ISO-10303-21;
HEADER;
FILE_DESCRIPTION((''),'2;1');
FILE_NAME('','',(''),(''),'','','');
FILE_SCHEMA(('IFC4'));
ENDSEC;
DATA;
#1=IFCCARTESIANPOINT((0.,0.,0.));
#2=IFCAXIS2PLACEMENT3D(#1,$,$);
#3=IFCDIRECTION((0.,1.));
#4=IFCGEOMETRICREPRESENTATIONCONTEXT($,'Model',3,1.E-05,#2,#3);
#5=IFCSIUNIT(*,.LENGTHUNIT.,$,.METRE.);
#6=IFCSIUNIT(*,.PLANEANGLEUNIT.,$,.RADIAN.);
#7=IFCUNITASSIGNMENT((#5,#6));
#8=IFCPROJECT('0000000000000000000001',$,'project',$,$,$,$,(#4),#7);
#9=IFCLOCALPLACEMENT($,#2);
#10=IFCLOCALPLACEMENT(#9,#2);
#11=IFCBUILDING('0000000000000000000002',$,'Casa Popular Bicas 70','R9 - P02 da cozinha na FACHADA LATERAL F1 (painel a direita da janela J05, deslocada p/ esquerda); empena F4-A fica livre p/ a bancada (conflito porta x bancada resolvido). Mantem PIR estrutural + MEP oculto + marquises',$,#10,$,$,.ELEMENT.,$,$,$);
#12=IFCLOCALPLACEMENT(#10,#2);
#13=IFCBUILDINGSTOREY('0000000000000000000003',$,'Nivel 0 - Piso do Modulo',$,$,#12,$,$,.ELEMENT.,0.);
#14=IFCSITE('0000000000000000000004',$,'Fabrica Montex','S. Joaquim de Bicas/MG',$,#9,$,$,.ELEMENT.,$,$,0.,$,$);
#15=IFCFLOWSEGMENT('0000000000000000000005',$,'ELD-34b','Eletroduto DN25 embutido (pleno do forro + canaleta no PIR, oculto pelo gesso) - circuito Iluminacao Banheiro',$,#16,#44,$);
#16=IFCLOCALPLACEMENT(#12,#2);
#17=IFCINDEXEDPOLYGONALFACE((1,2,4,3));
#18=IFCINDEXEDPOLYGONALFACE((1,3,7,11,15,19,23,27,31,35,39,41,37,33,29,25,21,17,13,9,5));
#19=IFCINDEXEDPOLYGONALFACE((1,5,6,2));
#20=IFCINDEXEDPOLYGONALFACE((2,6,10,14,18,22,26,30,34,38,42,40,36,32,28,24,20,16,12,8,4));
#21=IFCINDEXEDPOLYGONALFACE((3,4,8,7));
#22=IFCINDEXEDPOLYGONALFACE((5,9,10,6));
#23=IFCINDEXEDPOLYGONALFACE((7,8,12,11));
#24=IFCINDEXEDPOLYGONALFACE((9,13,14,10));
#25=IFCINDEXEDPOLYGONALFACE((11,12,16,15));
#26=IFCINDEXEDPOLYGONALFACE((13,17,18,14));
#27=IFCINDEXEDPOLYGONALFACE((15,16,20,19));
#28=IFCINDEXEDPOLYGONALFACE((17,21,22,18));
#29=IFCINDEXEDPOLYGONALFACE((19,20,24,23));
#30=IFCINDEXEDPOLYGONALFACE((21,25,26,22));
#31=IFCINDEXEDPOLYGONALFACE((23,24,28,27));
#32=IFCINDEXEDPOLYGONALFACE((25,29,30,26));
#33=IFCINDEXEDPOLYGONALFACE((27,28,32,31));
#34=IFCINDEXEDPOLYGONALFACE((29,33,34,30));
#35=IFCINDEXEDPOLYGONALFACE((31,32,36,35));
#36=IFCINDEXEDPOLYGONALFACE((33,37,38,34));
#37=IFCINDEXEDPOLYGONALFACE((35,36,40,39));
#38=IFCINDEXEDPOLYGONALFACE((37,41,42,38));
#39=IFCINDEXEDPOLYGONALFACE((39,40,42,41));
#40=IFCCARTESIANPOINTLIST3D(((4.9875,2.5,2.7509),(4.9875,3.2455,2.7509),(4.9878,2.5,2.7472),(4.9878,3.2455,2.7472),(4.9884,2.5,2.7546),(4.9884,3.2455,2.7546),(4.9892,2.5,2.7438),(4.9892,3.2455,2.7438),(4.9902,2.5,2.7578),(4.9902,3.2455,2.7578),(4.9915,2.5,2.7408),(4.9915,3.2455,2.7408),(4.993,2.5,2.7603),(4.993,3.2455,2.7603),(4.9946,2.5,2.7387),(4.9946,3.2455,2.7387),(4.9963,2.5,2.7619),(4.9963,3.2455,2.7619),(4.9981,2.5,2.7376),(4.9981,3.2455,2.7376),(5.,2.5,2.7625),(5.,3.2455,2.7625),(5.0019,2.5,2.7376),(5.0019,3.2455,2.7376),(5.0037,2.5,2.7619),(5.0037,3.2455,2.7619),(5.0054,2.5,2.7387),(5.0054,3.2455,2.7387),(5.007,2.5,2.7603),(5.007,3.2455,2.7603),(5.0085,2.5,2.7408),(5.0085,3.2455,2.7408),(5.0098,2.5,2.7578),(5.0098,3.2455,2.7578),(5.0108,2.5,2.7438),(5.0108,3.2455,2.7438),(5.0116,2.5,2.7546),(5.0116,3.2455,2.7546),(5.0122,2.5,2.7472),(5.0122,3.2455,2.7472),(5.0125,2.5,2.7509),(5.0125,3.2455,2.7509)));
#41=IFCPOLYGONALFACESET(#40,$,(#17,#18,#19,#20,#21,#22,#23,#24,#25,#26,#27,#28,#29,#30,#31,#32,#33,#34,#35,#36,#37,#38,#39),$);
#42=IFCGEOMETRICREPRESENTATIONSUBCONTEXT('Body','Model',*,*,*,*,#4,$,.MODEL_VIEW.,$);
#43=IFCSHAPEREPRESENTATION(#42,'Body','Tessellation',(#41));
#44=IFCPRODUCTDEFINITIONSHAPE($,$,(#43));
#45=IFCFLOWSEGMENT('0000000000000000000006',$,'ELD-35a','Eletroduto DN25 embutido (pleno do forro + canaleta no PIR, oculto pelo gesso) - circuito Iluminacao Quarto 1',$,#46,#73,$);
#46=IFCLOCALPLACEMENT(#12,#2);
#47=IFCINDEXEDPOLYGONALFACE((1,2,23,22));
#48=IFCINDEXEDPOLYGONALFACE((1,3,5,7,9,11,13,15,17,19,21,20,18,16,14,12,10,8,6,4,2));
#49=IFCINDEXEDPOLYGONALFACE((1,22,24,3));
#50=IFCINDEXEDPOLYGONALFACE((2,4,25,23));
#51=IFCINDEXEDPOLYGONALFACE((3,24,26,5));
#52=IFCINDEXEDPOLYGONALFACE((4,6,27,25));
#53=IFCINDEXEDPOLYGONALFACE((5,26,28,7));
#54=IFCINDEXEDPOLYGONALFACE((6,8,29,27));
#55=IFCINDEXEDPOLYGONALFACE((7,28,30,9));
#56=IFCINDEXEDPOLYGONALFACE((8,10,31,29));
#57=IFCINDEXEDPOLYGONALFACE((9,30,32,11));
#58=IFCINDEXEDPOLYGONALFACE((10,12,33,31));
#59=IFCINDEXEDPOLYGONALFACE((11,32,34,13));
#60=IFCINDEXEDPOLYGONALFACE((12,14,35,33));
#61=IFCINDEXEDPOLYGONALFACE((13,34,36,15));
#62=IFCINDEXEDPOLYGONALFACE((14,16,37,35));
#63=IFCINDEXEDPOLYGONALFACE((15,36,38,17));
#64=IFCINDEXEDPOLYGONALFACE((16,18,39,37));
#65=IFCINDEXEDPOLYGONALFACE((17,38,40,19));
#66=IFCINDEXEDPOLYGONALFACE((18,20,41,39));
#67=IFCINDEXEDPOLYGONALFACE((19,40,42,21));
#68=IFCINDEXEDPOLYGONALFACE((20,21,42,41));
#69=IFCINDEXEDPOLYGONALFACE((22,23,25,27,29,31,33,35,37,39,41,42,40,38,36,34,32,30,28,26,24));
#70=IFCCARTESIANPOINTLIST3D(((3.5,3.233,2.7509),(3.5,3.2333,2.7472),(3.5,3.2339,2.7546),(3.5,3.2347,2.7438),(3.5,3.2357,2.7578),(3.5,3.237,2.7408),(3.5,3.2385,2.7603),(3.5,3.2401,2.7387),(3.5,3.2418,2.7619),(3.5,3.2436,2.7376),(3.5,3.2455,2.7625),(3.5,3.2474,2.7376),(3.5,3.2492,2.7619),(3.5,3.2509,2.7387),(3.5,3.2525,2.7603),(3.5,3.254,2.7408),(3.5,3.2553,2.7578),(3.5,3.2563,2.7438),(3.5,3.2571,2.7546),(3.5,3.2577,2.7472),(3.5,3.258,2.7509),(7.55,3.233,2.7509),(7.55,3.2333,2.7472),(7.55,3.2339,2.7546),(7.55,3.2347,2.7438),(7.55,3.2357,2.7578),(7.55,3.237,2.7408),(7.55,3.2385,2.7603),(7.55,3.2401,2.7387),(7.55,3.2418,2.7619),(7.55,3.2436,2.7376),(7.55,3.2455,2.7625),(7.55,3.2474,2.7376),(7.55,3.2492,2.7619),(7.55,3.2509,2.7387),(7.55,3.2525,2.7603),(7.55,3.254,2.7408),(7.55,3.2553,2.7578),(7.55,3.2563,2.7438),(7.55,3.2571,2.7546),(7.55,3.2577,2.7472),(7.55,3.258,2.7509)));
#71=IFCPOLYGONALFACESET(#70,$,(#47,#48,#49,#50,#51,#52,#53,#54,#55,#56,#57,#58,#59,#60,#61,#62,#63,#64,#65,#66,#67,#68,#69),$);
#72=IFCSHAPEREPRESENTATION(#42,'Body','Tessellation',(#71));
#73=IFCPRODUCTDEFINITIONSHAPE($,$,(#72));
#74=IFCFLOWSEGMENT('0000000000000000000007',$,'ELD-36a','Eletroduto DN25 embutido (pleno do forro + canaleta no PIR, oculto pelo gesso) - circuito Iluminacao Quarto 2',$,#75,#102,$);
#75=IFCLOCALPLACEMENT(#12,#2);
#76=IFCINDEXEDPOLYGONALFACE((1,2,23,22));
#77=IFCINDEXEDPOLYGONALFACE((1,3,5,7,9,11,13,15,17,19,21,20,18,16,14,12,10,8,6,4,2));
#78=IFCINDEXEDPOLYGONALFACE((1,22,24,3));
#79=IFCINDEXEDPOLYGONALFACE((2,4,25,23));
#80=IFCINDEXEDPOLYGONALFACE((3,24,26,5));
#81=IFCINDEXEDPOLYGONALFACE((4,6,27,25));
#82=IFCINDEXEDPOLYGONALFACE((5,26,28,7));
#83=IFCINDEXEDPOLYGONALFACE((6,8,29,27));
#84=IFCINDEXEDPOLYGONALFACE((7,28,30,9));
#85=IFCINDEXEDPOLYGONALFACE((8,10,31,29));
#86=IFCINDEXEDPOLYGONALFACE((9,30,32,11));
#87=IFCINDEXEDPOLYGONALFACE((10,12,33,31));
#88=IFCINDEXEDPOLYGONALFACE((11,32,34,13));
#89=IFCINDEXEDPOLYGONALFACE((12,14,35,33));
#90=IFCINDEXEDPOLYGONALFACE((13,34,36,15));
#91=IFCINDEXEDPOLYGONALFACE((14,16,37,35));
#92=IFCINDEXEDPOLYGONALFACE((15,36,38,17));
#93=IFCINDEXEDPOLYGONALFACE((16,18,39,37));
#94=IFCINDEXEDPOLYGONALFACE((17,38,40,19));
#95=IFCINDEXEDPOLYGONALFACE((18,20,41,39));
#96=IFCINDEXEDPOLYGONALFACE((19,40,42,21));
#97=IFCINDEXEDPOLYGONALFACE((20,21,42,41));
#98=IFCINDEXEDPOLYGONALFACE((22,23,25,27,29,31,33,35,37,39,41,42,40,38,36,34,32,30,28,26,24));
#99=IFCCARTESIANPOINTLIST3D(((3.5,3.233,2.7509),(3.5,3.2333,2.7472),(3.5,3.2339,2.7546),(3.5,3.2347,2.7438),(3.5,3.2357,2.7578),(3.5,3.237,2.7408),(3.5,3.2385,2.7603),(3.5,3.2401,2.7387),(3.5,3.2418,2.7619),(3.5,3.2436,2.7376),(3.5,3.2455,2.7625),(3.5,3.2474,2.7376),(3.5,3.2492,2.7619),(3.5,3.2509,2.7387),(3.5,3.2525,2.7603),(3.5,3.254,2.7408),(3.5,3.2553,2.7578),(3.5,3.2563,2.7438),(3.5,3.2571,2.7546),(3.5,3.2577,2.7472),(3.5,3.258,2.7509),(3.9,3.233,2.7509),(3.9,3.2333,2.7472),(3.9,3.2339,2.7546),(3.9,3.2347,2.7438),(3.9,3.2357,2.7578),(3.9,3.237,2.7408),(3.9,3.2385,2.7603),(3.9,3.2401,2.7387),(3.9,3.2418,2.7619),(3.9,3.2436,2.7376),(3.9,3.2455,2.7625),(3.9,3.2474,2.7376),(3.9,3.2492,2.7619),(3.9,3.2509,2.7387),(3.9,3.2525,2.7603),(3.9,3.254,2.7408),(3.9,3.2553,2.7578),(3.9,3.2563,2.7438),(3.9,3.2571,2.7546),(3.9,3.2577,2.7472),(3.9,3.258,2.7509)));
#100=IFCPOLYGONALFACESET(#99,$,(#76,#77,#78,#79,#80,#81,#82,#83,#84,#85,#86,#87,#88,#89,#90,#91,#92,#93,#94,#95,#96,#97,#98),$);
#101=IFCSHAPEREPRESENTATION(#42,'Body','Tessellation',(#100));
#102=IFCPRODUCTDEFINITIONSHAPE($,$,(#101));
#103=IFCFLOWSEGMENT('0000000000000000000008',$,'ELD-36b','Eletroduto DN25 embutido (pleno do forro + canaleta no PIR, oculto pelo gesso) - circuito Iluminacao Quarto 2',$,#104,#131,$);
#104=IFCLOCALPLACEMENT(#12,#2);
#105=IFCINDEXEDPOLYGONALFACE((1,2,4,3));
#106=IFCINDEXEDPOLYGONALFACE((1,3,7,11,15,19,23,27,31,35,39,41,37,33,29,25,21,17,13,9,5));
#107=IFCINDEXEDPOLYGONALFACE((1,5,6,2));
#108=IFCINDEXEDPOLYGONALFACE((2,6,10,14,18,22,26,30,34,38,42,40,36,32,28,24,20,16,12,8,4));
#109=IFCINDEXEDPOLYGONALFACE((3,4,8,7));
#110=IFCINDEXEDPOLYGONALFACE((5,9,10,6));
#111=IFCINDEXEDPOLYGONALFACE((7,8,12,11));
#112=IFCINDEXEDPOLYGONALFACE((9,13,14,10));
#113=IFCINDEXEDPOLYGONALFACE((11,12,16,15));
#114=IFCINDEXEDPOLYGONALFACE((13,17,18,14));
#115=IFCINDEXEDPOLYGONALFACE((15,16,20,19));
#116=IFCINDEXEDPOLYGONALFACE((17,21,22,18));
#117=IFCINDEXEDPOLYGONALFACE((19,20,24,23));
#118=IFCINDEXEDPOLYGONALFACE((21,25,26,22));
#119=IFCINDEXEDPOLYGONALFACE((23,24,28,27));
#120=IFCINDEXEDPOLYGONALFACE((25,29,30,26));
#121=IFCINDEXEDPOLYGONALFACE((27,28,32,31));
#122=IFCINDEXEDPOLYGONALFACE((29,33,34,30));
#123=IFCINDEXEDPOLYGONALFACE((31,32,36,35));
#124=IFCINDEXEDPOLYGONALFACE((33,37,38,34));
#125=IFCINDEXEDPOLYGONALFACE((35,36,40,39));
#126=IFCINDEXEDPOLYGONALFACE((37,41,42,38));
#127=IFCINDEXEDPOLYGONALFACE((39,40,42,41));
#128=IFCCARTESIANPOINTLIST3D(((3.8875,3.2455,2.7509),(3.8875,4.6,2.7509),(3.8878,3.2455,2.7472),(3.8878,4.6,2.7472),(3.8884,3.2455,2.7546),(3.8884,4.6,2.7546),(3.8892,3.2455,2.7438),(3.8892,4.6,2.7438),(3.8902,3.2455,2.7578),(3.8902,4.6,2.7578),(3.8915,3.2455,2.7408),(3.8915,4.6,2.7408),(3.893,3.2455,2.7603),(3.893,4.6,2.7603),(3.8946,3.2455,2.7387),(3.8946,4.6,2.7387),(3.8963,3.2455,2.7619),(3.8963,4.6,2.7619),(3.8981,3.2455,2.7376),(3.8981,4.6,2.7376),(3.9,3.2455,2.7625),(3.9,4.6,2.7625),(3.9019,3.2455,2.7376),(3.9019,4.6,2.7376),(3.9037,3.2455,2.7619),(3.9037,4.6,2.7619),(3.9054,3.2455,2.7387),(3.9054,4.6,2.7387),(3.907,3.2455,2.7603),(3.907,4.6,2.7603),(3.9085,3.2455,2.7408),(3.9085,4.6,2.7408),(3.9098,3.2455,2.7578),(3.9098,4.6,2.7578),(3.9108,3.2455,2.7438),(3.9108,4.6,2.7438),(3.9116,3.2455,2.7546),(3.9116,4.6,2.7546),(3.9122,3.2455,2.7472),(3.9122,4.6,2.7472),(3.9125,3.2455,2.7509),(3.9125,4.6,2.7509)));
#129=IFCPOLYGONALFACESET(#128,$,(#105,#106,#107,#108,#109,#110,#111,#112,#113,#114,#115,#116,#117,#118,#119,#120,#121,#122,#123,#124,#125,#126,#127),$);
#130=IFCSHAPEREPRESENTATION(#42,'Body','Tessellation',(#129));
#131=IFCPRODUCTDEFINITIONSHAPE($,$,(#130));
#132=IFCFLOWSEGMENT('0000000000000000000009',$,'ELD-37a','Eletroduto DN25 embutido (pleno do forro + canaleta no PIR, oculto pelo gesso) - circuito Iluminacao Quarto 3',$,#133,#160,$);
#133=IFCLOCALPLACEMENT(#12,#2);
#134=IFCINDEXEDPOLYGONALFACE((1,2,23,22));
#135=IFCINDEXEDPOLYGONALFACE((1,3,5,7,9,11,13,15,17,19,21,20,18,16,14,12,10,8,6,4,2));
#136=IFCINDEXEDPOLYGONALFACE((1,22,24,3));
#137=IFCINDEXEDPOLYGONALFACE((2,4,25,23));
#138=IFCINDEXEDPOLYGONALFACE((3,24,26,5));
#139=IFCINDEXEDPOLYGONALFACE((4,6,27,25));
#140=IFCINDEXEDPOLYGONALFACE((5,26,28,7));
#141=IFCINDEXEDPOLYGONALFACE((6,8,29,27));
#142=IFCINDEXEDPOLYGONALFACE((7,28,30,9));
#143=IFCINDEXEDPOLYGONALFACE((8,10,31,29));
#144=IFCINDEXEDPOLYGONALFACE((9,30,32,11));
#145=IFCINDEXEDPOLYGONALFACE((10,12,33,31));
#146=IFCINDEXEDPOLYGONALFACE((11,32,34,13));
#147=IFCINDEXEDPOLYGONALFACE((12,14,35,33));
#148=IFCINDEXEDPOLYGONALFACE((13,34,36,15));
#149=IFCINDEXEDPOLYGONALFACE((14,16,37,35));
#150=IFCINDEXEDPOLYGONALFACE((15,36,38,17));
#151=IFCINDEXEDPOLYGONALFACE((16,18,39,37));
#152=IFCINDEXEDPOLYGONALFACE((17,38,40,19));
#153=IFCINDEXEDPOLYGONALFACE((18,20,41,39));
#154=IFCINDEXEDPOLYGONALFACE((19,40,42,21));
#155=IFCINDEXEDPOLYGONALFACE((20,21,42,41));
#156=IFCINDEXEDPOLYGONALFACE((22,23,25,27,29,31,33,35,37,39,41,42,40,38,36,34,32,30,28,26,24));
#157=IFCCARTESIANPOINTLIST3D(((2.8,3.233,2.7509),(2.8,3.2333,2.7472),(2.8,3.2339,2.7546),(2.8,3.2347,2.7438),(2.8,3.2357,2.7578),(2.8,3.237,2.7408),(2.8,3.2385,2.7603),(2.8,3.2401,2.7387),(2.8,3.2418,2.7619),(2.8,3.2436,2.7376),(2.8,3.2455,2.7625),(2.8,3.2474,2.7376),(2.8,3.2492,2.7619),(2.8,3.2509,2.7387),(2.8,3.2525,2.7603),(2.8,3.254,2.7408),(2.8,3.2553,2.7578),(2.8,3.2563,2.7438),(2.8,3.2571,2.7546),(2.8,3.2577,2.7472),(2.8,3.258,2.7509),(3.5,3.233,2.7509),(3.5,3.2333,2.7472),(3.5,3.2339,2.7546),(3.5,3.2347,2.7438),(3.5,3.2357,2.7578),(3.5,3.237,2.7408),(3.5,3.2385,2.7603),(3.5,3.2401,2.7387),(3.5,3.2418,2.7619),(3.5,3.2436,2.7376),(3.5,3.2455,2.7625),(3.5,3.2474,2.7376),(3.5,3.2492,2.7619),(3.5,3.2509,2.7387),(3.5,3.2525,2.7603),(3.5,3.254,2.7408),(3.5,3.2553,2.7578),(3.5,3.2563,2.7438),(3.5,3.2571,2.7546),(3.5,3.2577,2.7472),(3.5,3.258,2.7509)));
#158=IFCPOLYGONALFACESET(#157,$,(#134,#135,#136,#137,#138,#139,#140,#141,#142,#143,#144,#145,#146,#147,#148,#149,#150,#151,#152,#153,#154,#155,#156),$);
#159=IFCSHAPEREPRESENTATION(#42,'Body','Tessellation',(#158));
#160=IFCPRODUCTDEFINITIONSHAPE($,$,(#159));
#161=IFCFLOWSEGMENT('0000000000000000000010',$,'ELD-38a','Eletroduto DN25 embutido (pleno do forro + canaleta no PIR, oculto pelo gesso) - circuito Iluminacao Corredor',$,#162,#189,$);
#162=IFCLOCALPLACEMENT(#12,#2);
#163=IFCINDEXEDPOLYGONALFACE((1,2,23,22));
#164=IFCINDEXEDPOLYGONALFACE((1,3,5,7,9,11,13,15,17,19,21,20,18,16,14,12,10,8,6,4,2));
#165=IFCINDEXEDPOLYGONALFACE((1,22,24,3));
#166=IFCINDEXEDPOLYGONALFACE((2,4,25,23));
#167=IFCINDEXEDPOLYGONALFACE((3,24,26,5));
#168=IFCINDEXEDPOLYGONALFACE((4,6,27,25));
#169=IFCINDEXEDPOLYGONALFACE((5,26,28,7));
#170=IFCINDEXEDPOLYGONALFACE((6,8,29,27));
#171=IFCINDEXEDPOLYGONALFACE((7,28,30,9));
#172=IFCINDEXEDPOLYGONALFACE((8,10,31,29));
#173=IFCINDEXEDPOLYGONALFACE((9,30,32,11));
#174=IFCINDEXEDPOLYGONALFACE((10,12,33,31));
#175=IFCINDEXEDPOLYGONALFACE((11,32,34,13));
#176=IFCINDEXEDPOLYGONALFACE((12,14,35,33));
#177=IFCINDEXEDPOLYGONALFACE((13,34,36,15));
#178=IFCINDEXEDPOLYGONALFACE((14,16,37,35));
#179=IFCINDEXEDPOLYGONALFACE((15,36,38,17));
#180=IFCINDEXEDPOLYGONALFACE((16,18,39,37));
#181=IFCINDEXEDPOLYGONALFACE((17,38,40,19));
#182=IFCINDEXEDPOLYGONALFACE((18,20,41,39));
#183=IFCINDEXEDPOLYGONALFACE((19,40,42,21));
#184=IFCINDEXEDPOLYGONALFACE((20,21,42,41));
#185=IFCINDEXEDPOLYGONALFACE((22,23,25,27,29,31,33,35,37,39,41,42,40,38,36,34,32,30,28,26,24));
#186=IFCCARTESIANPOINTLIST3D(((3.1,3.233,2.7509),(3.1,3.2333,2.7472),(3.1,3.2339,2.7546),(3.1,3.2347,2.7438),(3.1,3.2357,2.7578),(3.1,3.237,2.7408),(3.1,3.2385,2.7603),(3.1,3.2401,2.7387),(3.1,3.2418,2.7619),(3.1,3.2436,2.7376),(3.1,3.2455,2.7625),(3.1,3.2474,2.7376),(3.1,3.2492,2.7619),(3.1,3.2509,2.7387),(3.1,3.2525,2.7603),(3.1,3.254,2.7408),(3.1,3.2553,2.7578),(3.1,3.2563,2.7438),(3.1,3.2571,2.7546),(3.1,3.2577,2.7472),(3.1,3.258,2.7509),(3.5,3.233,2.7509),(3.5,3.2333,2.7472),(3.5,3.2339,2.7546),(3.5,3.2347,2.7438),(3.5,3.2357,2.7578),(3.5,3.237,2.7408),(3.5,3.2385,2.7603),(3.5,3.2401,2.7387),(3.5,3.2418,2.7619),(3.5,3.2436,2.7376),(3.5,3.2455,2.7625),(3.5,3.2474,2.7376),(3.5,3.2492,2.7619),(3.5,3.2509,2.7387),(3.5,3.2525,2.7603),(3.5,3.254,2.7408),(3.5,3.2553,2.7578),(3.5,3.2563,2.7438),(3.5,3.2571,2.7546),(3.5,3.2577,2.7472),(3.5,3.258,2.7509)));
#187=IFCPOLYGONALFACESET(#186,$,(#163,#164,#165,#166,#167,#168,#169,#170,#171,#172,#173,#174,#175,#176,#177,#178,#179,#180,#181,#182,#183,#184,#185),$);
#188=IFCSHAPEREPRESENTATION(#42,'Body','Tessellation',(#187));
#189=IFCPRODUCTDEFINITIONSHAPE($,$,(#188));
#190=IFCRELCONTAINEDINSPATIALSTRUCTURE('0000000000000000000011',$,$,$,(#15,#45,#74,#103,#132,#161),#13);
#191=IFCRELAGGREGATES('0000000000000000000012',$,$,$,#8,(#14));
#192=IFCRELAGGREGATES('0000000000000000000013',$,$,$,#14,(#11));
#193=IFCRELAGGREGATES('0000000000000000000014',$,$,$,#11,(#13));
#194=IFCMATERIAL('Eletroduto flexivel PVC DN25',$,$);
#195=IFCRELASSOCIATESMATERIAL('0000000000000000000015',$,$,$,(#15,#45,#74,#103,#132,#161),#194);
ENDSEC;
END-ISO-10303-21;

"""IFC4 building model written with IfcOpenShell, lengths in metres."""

from ifc_helpers import new_model, si_unit, direction, frame, origin, origin_2d, place, context, subcontext, project, spatial, circle, extrude, material, element, save


model = new_model("IFC4")

# Units and contexts
model_context = context("Model", 3, precision=1e-05, world=origin(), true_north=direction((0.0, 1.0)))
body_context = subcontext(model_context, "Body", "Model", "MODEL_VIEW")
ifc_project = project(units=[si_unit("LENGTHUNIT", "METRE"), si_unit("PLANEANGLEUNIT", "RADIAN")], contexts=[model_context])

# Site, building, storey
site_placement = place(None, origin())
site = spatial("IfcSite", under=ifc_project, at=site_placement, Name="Fabrica Montex", Description="S. Joaquim de Bicas/MG", CompositionType="ELEMENT", RefElevation=0.0)
building_placement = place(site_placement, origin())
building = spatial("IfcBuilding", under=site, at=building_placement, Name="Casa Popular Bicas 70", Description="R9 - P02 da cozinha na FACHADA LATERAL F1 (painel a direita da janela J05, deslocada p/ esquerda); empena F4-A fica livre p/ a bancada (conflito porta x bancada resolvido). Mantem PIR estrutural + MEP oculto + marquises", CompositionType="ELEMENT")
storey_placement = place(building_placement, origin())
storey = spatial("IfcBuildingStorey", under=building, at=storey_placement, Name="Nivel 0 - Piso do Modulo", CompositionType="ELEMENT", Elevation=0.0)

# Flow segments
ifc_material_1 = material(Name="Eletroduto flexivel PVC DN25")
flow_segment_1_placement = place(storey_placement, frame((5.0, 3.2455, 2.75), z_axis=(0.0, -1.0, 0.0), x_axis=(0.0, 0.0, 1.0)))
element("IfcFlowSegment", 1, at=flow_segment_1_placement, inside=storey, material=ifc_material_1, Name="ELD-34b", Description="Eletroduto DN25 embutido (pleno do forro + canaleta no PIR, oculto pelo gesso) - circuito Iluminacao Banheiro", context=body_context, shape_type="SweptSolid", body=[
    extrude(circle(Radius=0.0125, at=origin_2d()), origin(), (0.0, 0.0, 1.0), 0.7455),
])
flow_segment_2_placement = place(storey_placement, frame((3.5, 3.2455, 2.75), z_axis=(1.0, 0.0, 0.0), x_axis=(0.0, 0.0, 1.0)))
element("IfcFlowSegment", 2, at=flow_segment_2_placement, inside=storey, material=ifc_material_1, Name="ELD-35a", Description="Eletroduto DN25 embutido (pleno do forro + canaleta no PIR, oculto pelo gesso) - circuito Iluminacao Quarto 1", context=body_context, shape_type="SweptSolid", body=[
    extrude(circle(Radius=0.0125, at=origin_2d()), origin(), (0.0, 0.0, 1.0), 4.05),
])
flow_segment_3_placement = place(storey_placement, frame((3.5, 3.2455, 2.75), z_axis=(1.0, 0.0, 0.0), x_axis=(0.0, 0.0, 1.0)))
element("IfcFlowSegment", 3, at=flow_segment_3_placement, inside=storey, material=ifc_material_1, Name="ELD-36a", Description="Eletroduto DN25 embutido (pleno do forro + canaleta no PIR, oculto pelo gesso) - circuito Iluminacao Quarto 2", context=body_context, shape_type="SweptSolid", body=[
    extrude(circle(Radius=0.0125, at=origin_2d()), origin(), (0.0, 0.0, 1.0), 0.4),
])
flow_segment_4_placement = place(storey_placement, frame((3.9, 3.2455, 2.75), z_axis=(0.0, 1.0, 0.0), x_axis=(0.0, 0.0, 1.0)))
element("IfcFlowSegment", 4, at=flow_segment_4_placement, inside=storey, material=ifc_material_1, Name="ELD-36b", Description="Eletroduto DN25 embutido (pleno do forro + canaleta no PIR, oculto pelo gesso) - circuito Iluminacao Quarto 2", context=body_context, shape_type="SweptSolid", body=[
    extrude(circle(Radius=0.0125, at=origin_2d()), origin(), (0.0, 0.0, 1.0), 1.3545),
])
flow_segment_5_placement = place(storey_placement, frame((3.5, 3.2455, 2.75), z_axis=(-1.0, 0.0, 0.0), x_axis=(0.0, 0.0, 1.0)))
element("IfcFlowSegment", 5, at=flow_segment_5_placement, inside=storey, material=ifc_material_1, Name="ELD-37a", Description="Eletroduto DN25 embutido (pleno do forro + canaleta no PIR, oculto pelo gesso) - circuito Iluminacao Quarto 3", context=body_context, shape_type="SweptSolid", body=[
    extrude(circle(Radius=0.0125, at=origin_2d()), origin(), (0.0, 0.0, 1.0), 0.7),
])
flow_segment_6_placement = place(storey_placement, frame((3.5, 3.2455, 2.75), z_axis=(-1.0, 0.0, 0.0), x_axis=(0.0, 0.0, 1.0)))
element("IfcFlowSegment", 6, at=flow_segment_6_placement, inside=storey, material=ifc_material_1, Name="ELD-38a", Description="Eletroduto DN25 embutido (pleno do forro + canaleta no PIR, oculto pelo gesso) - circuito Iluminacao Corredor", context=body_context, shape_type="SweptSolid", body=[
    extrude(circle(Radius=0.0125, at=origin_2d()), origin(), (0.0, 0.0, 1.0), 0.4),
])

save(model, "model.ifc")
